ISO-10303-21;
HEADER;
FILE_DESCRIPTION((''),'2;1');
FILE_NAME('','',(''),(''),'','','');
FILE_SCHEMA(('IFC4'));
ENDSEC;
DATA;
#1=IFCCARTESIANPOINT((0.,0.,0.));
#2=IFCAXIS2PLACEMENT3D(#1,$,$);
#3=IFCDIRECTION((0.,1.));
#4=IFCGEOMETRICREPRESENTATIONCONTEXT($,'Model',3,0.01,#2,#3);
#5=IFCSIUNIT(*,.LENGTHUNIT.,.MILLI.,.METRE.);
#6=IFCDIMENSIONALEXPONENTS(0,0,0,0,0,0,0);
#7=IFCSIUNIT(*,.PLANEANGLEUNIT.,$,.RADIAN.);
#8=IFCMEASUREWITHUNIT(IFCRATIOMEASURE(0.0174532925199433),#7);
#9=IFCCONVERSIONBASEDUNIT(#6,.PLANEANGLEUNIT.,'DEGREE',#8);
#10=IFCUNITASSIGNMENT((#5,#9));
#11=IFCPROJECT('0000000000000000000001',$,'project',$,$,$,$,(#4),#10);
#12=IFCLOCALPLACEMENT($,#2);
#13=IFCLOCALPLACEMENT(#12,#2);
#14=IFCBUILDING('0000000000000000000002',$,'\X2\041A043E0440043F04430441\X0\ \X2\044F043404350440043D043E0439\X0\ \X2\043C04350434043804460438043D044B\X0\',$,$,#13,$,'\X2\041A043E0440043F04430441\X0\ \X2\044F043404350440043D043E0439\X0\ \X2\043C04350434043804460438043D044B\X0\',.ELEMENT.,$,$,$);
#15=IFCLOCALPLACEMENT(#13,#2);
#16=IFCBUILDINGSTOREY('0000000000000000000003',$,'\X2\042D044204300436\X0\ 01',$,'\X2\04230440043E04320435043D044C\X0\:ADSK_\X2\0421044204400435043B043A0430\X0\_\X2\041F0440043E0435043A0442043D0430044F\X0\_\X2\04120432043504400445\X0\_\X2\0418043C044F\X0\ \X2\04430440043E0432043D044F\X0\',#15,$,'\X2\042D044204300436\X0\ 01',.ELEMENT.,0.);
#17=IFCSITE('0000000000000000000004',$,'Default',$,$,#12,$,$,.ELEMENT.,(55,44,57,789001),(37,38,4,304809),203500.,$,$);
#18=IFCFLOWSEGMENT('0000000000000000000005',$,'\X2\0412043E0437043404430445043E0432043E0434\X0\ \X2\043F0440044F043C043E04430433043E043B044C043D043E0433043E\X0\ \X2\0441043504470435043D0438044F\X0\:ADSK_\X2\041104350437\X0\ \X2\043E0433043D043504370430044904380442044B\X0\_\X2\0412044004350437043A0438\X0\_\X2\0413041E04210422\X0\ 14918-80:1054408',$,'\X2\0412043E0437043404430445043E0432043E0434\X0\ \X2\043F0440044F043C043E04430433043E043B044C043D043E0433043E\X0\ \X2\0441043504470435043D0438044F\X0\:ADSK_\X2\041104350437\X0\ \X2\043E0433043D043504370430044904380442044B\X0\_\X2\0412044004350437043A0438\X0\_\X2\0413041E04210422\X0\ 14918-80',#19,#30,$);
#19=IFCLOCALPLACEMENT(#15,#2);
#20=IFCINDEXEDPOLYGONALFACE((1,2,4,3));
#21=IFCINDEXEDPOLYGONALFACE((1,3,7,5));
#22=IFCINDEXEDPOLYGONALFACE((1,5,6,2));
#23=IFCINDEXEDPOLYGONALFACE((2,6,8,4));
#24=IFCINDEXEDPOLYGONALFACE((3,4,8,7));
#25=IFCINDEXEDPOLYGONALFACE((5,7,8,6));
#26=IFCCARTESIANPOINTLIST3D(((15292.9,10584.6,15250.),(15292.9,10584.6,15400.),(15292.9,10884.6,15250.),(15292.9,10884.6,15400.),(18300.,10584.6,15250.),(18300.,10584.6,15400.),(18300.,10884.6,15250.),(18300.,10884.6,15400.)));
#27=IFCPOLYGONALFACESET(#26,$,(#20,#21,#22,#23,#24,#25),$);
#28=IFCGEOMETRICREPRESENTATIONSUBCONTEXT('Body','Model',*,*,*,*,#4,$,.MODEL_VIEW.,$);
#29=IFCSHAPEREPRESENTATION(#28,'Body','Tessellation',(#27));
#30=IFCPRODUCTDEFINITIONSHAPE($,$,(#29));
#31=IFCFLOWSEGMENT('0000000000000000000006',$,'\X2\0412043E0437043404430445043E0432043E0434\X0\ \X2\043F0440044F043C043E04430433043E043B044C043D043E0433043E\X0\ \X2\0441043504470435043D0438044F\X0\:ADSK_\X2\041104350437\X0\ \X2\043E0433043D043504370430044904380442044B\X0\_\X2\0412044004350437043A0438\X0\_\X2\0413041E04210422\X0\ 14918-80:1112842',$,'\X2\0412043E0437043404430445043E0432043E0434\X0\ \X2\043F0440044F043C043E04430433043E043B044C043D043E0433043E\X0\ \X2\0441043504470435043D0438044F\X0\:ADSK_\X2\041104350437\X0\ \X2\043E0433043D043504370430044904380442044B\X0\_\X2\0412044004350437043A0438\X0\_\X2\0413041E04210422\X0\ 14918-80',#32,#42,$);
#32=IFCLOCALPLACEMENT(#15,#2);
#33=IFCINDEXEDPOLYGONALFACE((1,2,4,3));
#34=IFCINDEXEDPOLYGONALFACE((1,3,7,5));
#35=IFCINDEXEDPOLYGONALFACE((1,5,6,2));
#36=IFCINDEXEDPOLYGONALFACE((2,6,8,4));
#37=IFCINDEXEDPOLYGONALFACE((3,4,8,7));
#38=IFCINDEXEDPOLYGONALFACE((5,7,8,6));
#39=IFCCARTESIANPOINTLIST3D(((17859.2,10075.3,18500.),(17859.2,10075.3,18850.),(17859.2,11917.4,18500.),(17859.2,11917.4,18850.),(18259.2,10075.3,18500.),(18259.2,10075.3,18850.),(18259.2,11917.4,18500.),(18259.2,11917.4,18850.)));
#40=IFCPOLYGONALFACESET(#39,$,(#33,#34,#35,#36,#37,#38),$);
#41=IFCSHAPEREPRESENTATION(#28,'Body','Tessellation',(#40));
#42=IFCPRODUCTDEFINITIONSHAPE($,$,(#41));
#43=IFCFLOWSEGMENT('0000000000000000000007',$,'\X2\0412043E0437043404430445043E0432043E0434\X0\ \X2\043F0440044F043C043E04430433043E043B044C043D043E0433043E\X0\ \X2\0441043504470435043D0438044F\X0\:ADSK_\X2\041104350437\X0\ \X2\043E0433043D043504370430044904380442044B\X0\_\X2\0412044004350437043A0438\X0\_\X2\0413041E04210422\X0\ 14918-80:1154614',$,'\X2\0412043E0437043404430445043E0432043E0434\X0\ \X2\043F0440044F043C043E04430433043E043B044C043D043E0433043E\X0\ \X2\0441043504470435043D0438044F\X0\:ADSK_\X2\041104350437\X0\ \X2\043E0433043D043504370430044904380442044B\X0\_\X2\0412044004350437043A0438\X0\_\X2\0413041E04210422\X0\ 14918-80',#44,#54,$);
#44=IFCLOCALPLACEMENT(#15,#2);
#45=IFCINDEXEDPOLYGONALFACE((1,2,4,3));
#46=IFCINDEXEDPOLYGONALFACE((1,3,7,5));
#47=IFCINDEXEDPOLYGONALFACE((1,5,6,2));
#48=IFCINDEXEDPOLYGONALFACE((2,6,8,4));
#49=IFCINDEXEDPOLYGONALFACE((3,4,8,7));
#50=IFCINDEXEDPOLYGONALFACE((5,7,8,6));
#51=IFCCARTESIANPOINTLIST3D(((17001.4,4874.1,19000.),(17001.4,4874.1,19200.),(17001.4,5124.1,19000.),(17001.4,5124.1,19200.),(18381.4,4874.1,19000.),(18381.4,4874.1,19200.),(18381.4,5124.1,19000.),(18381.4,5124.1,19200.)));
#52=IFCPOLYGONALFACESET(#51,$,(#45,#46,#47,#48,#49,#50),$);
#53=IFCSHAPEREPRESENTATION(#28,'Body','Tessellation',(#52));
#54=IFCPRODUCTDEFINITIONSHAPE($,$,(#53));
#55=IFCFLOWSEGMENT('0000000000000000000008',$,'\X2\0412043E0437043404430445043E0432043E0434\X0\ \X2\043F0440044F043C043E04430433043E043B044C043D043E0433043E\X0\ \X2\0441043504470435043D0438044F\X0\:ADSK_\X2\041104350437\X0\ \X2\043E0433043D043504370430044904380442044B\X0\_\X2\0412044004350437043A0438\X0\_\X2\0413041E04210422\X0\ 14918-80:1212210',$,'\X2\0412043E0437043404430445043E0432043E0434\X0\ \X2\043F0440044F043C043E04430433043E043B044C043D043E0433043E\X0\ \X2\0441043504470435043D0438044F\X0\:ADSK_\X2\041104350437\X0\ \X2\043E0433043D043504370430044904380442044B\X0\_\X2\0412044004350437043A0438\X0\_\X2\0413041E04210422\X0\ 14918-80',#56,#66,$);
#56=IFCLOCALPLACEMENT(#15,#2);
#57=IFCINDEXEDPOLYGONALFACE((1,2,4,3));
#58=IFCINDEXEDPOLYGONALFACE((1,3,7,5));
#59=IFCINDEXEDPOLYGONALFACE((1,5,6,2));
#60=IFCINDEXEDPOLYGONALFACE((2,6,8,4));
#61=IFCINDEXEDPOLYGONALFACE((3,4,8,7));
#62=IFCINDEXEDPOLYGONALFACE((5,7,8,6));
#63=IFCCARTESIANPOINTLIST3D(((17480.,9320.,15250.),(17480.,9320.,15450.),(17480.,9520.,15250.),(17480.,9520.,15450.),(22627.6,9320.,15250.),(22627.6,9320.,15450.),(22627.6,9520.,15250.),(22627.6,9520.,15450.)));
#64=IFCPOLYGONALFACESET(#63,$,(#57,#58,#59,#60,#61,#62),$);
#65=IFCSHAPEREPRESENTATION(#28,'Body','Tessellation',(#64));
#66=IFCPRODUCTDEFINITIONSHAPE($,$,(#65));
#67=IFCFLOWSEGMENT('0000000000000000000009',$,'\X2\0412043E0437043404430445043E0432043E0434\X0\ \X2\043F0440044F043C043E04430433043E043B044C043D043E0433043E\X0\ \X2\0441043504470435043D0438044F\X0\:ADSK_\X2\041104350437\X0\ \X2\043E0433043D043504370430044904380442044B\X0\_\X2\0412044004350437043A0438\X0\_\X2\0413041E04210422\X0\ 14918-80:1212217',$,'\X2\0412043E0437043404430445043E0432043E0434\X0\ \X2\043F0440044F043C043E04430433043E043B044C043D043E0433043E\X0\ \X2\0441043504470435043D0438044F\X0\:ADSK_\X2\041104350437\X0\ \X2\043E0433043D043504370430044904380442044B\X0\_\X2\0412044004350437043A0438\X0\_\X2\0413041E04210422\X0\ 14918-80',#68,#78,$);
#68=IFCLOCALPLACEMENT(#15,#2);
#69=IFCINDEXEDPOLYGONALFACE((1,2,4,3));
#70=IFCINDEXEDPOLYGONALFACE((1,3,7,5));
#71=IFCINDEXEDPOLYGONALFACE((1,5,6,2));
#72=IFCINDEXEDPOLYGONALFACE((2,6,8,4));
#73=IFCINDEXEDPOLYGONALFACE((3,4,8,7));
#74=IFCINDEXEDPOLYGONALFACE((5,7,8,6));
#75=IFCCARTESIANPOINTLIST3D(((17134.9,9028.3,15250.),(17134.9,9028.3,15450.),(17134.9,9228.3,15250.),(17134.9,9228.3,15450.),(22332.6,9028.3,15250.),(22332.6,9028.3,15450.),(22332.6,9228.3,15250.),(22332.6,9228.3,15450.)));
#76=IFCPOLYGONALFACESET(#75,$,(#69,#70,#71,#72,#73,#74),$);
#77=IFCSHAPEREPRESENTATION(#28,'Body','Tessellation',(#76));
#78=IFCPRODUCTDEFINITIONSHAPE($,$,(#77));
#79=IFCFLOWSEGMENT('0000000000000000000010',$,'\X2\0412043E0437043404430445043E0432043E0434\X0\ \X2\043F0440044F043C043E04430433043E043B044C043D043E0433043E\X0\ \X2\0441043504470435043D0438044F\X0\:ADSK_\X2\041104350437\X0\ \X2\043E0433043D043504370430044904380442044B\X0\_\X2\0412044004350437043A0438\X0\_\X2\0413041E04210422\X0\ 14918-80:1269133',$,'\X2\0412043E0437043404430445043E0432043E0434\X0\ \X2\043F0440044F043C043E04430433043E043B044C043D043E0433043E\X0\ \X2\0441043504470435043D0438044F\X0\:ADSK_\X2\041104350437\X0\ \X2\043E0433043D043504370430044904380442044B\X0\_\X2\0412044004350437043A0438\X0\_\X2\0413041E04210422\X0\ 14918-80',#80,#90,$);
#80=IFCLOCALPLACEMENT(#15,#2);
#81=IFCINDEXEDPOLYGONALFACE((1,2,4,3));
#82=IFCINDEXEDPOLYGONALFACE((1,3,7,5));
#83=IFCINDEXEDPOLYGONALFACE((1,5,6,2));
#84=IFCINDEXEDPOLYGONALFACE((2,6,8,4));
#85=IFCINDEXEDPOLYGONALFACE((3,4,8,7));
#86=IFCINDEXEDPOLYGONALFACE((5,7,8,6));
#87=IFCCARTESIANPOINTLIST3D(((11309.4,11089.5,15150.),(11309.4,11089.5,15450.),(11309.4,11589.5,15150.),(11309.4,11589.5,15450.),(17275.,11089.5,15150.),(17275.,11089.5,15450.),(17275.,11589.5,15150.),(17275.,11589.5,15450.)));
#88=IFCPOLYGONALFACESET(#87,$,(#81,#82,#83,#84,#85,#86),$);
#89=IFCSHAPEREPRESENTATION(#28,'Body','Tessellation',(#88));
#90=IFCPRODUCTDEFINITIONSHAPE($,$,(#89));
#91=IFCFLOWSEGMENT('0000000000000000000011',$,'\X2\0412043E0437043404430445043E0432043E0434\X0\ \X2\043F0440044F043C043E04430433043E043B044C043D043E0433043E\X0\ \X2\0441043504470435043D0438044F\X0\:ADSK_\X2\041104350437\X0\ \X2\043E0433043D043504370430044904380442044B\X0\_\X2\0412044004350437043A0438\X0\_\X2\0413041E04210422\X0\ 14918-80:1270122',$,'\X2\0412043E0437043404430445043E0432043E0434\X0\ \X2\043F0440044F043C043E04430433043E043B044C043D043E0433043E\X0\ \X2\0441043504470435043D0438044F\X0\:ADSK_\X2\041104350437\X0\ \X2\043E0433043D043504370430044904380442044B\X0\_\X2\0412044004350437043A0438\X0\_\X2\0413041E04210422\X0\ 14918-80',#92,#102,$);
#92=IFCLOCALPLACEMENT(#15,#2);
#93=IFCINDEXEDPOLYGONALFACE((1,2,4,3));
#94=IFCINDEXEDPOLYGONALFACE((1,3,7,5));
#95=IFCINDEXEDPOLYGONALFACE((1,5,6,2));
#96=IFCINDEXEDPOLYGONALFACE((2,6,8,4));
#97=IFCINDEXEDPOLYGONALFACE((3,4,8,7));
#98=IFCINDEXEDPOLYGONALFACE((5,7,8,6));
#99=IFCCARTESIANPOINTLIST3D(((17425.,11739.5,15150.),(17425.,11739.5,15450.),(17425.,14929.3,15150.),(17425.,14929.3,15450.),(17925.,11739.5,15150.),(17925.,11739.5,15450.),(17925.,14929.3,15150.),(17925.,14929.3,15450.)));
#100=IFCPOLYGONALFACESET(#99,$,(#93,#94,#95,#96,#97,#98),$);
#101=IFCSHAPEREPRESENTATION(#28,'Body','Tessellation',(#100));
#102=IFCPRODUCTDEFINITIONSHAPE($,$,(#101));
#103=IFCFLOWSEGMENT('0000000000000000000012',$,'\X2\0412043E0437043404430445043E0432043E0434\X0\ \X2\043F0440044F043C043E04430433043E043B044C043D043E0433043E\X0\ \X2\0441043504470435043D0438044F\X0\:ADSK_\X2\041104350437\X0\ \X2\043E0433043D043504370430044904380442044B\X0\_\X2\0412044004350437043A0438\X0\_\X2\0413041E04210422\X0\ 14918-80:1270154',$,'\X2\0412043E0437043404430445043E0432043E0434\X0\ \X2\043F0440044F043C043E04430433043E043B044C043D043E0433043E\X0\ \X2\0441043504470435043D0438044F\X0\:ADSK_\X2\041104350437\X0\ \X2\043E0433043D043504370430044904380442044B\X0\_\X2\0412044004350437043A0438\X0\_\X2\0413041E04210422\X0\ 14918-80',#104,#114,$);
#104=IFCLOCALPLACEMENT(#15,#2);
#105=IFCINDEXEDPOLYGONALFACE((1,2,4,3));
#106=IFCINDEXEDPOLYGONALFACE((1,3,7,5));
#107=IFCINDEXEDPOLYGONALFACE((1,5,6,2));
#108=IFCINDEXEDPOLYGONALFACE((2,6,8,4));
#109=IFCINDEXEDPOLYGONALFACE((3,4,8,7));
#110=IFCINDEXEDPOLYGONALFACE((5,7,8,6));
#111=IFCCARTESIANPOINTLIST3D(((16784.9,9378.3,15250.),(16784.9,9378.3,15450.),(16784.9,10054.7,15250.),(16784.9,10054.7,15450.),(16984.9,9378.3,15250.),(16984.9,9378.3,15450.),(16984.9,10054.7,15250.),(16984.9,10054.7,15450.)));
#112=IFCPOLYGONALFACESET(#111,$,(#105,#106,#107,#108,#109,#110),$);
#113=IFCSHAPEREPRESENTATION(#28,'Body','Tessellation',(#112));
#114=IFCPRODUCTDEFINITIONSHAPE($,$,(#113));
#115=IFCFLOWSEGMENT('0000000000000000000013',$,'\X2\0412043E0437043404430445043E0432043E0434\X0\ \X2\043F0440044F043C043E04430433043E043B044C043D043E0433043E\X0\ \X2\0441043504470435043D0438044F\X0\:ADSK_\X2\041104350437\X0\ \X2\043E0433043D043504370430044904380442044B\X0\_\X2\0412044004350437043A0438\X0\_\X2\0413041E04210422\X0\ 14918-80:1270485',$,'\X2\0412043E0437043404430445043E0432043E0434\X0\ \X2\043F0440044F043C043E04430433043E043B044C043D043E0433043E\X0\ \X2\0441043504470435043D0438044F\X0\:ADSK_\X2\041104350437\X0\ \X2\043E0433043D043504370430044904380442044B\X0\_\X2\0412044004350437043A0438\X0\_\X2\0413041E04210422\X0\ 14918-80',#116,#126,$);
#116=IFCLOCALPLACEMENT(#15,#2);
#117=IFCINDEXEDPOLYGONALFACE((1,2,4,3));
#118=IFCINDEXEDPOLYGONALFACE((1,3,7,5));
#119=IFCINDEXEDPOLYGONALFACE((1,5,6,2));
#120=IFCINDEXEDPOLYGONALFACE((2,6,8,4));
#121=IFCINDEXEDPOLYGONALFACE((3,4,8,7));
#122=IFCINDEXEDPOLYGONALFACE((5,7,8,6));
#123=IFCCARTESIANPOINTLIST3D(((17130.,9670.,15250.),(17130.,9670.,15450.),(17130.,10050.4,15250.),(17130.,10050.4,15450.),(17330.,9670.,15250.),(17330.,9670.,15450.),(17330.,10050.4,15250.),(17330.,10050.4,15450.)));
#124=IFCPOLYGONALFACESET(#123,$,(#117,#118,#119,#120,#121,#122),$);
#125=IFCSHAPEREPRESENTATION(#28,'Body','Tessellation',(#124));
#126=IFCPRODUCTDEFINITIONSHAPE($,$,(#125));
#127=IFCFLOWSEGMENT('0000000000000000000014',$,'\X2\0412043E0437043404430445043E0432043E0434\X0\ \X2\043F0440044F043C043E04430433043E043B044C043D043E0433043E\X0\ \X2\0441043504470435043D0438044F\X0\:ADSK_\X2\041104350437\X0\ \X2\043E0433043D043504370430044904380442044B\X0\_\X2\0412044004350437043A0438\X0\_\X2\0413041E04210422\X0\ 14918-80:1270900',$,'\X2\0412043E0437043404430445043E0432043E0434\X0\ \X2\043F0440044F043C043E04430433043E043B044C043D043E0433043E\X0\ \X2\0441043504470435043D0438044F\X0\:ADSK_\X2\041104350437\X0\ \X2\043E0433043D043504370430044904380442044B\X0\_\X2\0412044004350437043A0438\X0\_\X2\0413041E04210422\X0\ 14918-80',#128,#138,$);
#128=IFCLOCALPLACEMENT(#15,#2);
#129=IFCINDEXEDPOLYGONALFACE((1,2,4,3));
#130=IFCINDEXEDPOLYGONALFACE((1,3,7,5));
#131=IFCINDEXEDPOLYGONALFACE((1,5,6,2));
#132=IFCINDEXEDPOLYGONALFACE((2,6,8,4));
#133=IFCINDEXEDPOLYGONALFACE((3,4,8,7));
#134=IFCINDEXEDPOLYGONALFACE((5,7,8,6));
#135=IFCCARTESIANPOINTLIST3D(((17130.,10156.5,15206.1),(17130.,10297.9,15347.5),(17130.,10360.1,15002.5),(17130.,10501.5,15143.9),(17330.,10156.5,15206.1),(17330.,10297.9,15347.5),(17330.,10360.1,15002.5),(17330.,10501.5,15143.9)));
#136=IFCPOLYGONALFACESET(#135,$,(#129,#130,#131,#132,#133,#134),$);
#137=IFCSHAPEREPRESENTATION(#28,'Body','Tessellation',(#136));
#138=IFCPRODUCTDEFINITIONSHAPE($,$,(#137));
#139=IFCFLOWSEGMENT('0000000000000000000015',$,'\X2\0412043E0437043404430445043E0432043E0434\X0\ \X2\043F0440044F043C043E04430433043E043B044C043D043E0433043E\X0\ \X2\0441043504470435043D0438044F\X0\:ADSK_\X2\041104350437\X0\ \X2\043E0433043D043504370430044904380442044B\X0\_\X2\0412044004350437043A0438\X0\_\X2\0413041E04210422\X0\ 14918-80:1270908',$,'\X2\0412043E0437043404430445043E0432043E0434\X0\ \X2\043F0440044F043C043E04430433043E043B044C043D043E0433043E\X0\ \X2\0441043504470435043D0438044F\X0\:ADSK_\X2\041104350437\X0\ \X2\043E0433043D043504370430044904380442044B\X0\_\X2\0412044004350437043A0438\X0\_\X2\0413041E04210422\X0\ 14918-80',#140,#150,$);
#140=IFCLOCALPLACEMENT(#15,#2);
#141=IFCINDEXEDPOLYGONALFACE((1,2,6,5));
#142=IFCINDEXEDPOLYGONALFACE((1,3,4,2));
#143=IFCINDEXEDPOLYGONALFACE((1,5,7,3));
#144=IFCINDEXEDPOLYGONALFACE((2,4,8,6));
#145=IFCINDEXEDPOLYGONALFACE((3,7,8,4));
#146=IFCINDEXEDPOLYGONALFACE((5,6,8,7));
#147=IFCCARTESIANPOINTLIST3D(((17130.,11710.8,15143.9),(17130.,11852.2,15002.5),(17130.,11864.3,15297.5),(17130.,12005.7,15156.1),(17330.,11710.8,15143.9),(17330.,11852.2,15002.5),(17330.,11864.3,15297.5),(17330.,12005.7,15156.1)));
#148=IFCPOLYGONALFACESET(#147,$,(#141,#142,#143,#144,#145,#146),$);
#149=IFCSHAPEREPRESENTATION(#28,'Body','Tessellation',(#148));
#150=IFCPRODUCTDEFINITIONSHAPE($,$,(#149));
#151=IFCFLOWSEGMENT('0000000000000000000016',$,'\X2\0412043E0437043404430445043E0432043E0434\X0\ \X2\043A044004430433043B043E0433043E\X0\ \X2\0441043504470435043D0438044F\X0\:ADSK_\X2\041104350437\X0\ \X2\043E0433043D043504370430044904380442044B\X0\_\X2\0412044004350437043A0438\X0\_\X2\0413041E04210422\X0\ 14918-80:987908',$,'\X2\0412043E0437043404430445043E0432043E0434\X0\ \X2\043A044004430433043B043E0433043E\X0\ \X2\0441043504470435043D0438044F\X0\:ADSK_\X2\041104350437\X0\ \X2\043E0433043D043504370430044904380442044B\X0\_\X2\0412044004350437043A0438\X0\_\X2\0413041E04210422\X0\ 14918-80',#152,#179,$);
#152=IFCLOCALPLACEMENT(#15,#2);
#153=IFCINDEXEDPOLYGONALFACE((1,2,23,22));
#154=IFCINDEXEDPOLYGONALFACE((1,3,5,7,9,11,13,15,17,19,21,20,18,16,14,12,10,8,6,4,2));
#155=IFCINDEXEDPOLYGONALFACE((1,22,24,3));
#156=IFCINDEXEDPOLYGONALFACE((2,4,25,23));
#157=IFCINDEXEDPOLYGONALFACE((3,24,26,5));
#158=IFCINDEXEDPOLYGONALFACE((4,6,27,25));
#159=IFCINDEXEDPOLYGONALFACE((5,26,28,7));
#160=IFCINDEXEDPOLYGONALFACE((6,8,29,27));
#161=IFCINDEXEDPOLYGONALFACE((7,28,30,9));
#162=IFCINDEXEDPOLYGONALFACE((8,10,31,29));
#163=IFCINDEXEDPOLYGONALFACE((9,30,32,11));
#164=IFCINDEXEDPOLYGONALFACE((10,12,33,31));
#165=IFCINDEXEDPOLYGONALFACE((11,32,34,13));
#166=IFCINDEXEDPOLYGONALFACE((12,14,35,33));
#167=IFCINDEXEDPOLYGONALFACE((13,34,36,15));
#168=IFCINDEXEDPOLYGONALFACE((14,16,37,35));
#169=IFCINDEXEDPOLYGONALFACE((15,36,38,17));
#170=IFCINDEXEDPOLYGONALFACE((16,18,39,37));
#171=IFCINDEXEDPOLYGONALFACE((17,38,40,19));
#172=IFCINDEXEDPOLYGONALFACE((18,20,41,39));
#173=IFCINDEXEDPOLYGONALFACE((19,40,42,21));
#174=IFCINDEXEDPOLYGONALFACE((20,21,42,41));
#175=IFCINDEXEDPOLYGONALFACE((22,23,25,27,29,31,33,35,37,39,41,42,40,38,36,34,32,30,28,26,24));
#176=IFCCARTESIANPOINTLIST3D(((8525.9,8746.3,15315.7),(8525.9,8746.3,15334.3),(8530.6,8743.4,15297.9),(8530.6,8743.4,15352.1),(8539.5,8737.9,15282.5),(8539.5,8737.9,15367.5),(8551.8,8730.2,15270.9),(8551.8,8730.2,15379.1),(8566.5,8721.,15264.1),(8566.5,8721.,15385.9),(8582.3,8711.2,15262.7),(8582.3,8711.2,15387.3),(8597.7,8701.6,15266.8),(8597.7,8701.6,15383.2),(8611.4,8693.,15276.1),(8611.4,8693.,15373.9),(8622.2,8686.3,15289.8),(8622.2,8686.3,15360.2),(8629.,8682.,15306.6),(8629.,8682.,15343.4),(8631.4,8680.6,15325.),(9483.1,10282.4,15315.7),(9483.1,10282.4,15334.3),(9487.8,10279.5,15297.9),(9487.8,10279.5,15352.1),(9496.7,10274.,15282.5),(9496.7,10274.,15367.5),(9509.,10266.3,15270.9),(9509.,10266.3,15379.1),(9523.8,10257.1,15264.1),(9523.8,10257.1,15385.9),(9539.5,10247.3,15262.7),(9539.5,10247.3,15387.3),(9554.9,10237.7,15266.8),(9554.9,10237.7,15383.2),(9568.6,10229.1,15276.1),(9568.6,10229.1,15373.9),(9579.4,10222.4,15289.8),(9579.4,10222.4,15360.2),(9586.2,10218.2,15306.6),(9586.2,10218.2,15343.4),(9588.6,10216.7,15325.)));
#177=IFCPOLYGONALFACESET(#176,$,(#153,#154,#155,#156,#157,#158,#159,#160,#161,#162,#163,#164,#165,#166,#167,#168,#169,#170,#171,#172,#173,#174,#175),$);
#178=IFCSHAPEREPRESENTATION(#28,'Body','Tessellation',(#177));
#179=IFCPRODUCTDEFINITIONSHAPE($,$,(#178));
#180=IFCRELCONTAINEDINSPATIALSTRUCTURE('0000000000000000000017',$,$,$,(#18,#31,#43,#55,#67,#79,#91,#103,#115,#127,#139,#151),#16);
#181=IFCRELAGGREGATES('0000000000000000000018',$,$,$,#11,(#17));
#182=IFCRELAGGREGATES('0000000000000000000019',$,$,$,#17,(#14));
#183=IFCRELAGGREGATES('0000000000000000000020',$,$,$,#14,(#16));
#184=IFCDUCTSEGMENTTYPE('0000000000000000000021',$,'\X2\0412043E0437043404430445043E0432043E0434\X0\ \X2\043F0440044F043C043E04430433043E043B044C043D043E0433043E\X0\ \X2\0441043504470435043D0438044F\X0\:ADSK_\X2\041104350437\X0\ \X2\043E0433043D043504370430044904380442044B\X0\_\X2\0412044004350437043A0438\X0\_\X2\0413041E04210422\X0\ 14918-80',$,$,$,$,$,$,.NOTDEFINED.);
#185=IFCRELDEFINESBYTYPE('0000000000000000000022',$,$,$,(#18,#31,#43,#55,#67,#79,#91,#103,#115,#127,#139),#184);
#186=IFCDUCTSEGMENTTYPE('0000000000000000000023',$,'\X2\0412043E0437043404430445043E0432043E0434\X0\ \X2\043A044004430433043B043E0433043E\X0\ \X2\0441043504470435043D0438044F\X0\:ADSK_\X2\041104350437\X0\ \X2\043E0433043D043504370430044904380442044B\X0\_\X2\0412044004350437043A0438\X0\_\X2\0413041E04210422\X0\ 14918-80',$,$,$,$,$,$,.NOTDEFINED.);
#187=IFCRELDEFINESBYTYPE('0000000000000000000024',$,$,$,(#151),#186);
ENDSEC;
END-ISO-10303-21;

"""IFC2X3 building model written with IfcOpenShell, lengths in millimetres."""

from ifc_helpers import new_model, entity, si_unit, converted_unit, direction, frame, frame_2d, origin, origin_2d_with_axis, place, context, subcontext, project, spatial, rectangle, circle, extrude, type_object, element, save


model = new_model("IFC2X3")

# Units and contexts
model_context = context("Model", 3, precision=0.01, world=origin(), true_north=direction((0.0, 1.0)))
body_context = subcontext(model_context, "Body", "Model", "MODEL_VIEW")
ifc_project = project(units=[si_unit("LENGTHUNIT", "METRE", prefix="MILLI"), converted_unit("PLANEANGLEUNIT", "DEGREE", entity("IfcRatioMeasure", 0.0174532925199433), si_unit("PLANEANGLEUNIT", "RADIAN"), dimensions=[0, 0, 0, 0, 0, 0, 0])], contexts=[model_context])

# Site, building, storey
site_placement = place(None, origin())
site = spatial("IfcSite", under=ifc_project, at=site_placement, Name="Default", CompositionType="ELEMENT", RefLatitude=(55, 44, 57, 789001), RefLongitude=(37, 38, 4, 304809), RefElevation=203500.0)
building_placement = place(site_placement, origin())
building = spatial("IfcBuilding", under=site, at=building_placement, Name="Корпус ядерной медицины", LongName="Корпус ядерной медицины", CompositionType="ELEMENT")
storey_placement = place(building_placement, origin())
storey = spatial("IfcBuildingStorey", under=building, at=storey_placement, Name="Этаж 01", ObjectType="Уровень:ADSK_Стрелка_Проектная_Вверх_Имя уровня", LongName="Этаж 01", CompositionType="ELEMENT", Elevation=0.0)

# Flow segments
duct_segment_type_1 = type_object("IfcDuctSegmentType", Name="Воздуховод прямоугольного сечения:ADSK_Без огнезащиты_Врезки_ГОСТ 14918-80", PredefinedType="NOTDEFINED")
flow_segment_1_placement = place(storey_placement, frame((15292.9, 10584.6, 15250.0)))
element("IfcFlowSegment", 1, at=flow_segment_1_placement, inside=storey, type_object=duct_segment_type_1, Name="Воздуховод прямоугольного сечения:ADSK_Без огнезащиты_Врезки_ГОСТ 14918-80:1054408", ObjectType="Воздуховод прямоугольного сечения:ADSK_Без огнезащиты_Врезки_ГОСТ 14918-80", context=body_context, shape_type="SweptSolid", body=[
    extrude(rectangle(XDim=3007.1, YDim=300.0, at=origin_2d_with_axis()), frame((1503.5, 150.0, 0.0)), (0.0, 0.0, 1.0), 150.0),
])
flow_segment_2_placement = place(storey_placement, frame((17859.2, 10075.3, 18500.0)))
element("IfcFlowSegment", 2, at=flow_segment_2_placement, inside=storey, type_object=duct_segment_type_1, Name="Воздуховод прямоугольного сечения:ADSK_Без огнезащиты_Врезки_ГОСТ 14918-80:1112842", ObjectType="Воздуховод прямоугольного сечения:ADSK_Без огнезащиты_Врезки_ГОСТ 14918-80", context=body_context, shape_type="SweptSolid", body=[
    extrude(rectangle(XDim=1842.1, YDim=400.0, at=origin_2d_with_axis()), frame((200.0, 921.0, 0.0), z_axis=(0.0, 0.0, 1.0), x_axis=(0.0, -1.0, 0.0)), (0.0, 0.0, 1.0), 350.0),
])
flow_segment_3_placement = place(storey_placement, frame((17001.4, 4874.1, 19000.0)))
element("IfcFlowSegment", 3, at=flow_segment_3_placement, inside=storey, type_object=duct_segment_type_1, Name="Воздуховод прямоугольного сечения:ADSK_Без огнезащиты_Врезки_ГОСТ 14918-80:1154614", ObjectType="Воздуховод прямоугольного сечения:ADSK_Без огнезащиты_Врезки_ГОСТ 14918-80", context=body_context, shape_type="SweptSolid", body=[
    extrude(rectangle(XDim=1380.0, YDim=250.0, at=origin_2d_with_axis()), frame((690.0, 125.0, 0.0), z_axis=(0.0, 0.0, 1.0), x_axis=(-1.0, 0.0, 0.0)), (0.0, 0.0, 1.0), 200.0),
])
flow_segment_4_placement = place(storey_placement, frame((17480.0, 9320.0, 15250.0)))
element("IfcFlowSegment", 4, at=flow_segment_4_placement, inside=storey, type_object=duct_segment_type_1, Name="Воздуховод прямоугольного сечения:ADSK_Без огнезащиты_Врезки_ГОСТ 14918-80:1212210", ObjectType="Воздуховод прямоугольного сечения:ADSK_Без огнезащиты_Врезки_ГОСТ 14918-80", context=body_context, shape_type="SweptSolid", body=[
    extrude(rectangle(XDim=5147.6, YDim=200.0, at=origin_2d_with_axis()), frame((2573.8, 100.0, 0.0), z_axis=(0.0, 0.0, 1.0), x_axis=(-1.0, 0.0, 0.0)), (0.0, 0.0, 1.0), 200.0),
])
flow_segment_5_placement = place(storey_placement, frame((17134.9, 9028.3, 15250.0)))
element("IfcFlowSegment", 5, at=flow_segment_5_placement, inside=storey, type_object=duct_segment_type_1, Name="Воздуховод прямоугольного сечения:ADSK_Без огнезащиты_Врезки_ГОСТ 14918-80:1212217", ObjectType="Воздуховод прямоугольного сечения:ADSK_Без огнезащиты_Врезки_ГОСТ 14918-80", context=body_context, shape_type="SweptSolid", body=[
    extrude(rectangle(XDim=5197.6, YDim=200.0, at=origin_2d_with_axis()), frame((2598.8, 100.0, 0.0), z_axis=(0.0, 0.0, 1.0), x_axis=(-1.0, 0.0, 0.0)), (0.0, 0.0, 1.0), 200.0),
])
flow_segment_6_placement = place(storey_placement, frame((11309.4, 11089.5, 15150.0)))
element("IfcFlowSegment", 6, at=flow_segment_6_placement, inside=storey, type_object=duct_segment_type_1, Name="Воздуховод прямоугольного сечения:ADSK_Без огнезащиты_Врезки_ГОСТ 14918-80:1269133", ObjectType="Воздуховод прямоугольного сечения:ADSK_Без огнезащиты_Врезки_ГОСТ 14918-80", context=body_context, shape_type="SweptSolid", body=[
    extrude(rectangle(XDim=5965.6, YDim=500.0, at=origin_2d_with_axis()), frame((2982.8, 250.0, 0.0)), (0.0, 0.0, 1.0), 300.0),
])
flow_segment_7_placement = place(storey_placement, frame((17425.0, 11739.5, 15150.0)))
element("IfcFlowSegment", 7, at=flow_segment_7_placement, inside=storey, type_object=duct_segment_type_1, Name="Воздуховод прямоугольного сечения:ADSK_Без огнезащиты_Врезки_ГОСТ 14918-80:1270122", ObjectType="Воздуховод прямоугольного сечения:ADSK_Без огнезащиты_Врезки_ГОСТ 14918-80", context=body_context, shape_type="SweptSolid", body=[
    extrude(rectangle(XDim=3189.8, YDim=500.0, at=origin_2d_with_axis()), frame((250.0, 1594.9, 0.0), z_axis=(0.0, 0.0, 1.0), x_axis=(0.0, -1.0, 0.0)), (0.0, 0.0, 1.0), 300.0),
])
flow_segment_8_placement = place(storey_placement, frame((16784.9, 9378.3, 15250.0)))
element("IfcFlowSegment", 8, at=flow_segment_8_placement, inside=storey, type_object=duct_segment_type_1, Name="Воздуховод прямоугольного сечения:ADSK_Без огнезащиты_Врезки_ГОСТ 14918-80:1270154", ObjectType="Воздуховод прямоугольного сечения:ADSK_Без огнезащиты_Врезки_ГОСТ 14918-80", context=body_context, shape_type="SweptSolid", body=[
    extrude(rectangle(XDim=676.4, YDim=200.0, at=origin_2d_with_axis()), frame((100.0, 338.2, 0.0), z_axis=(0.0, 0.0, 1.0), x_axis=(0.0, 1.0, 0.0)), (0.0, 0.0, 1.0), 200.0),
])
flow_segment_9_placement = place(storey_placement, frame((17130.0, 9670.0, 15250.0)))
element("IfcFlowSegment", 9, at=flow_segment_9_placement, inside=storey, type_object=duct_segment_type_1, Name="Воздуховод прямоугольного сечения:ADSK_Без огнезащиты_Врезки_ГОСТ 14918-80:1270485", ObjectType="Воздуховод прямоугольного сечения:ADSK_Без огнезащиты_Врезки_ГОСТ 14918-80", context=body_context, shape_type="SweptSolid", body=[
    extrude(rectangle(XDim=380.4, YDim=200.0, at=origin_2d_with_axis()), frame((100.0, 190.2, 0.0), z_axis=(0.0, 0.0, 1.0), x_axis=(0.0, 1.0, 0.0)), (0.0, 0.0, 1.0), 200.0),
])
flow_segment_10_placement = place(storey_placement, frame((17130.0, 10156.5, 15002.5)))
element("IfcFlowSegment", 10, at=flow_segment_10_placement, inside=storey, type_object=duct_segment_type_1, Name="Воздуховод прямоугольного сечения:ADSK_Без огнезащиты_Врезки_ГОСТ 14918-80:1270900", ObjectType="Воздуховод прямоугольного сечения:ADSK_Без огнезащиты_Врезки_ГОСТ 14918-80", context=body_context, shape_type="SweptSolid", body=[
    extrude(rectangle(XDim=200.0, YDim=200.0, at=frame_2d((0.0, 0.0), x_axis=(0.0, 1.0))), frame((100.0, 274.3, 70.7), z_axis=(0.0, -0.707107, 0.707107), x_axis=(1.0, 0.0, 0.0)), (0.0, 0.0, 1.0), 287.9),
])
flow_segment_11_placement = place(storey_placement, frame((17130.0, 11710.8, 15002.5)))
element("IfcFlowSegment", 11, at=flow_segment_11_placement, inside=storey, type_object=duct_segment_type_1, Name="Воздуховод прямоугольного сечения:ADSK_Без огнезащиты_Врезки_ГОСТ 14918-80:1270908", ObjectType="Воздуховод прямоугольного сечения:ADSK_Без огнезащиты_Врезки_ГОСТ 14918-80", context=body_context, shape_type="SweptSolid", body=[
    extrude(rectangle(XDim=200.0, YDim=200.0, at=frame_2d((0.0, 0.0), x_axis=(0.0, 1.0))), frame((100.0, 70.7, 70.7), z_axis=(0.0, 0.707107, 0.707107), x_axis=(-1.0, 0.0, 0.0)), (0.0, 0.0, 1.0), 217.2),
])
duct_segment_type_2 = type_object("IfcDuctSegmentType", Name="Воздуховод круглого сечения:ADSK_Без огнезащиты_Врезки_ГОСТ 14918-80", PredefinedType="NOTDEFINED")
flow_segment_12_placement = place(storey_placement, frame((8523.7, 8679.0, 15260.9)))
element("IfcFlowSegment", 12, at=flow_segment_12_placement, inside=storey, type_object=duct_segment_type_2, Name="Воздуховод круглого сечения:ADSK_Без огнезащиты_Врезки_ГОСТ 14918-80:987908", ObjectType="Воздуховод круглого сечения:ADSK_Без огнезащиты_Врезки_ГОСТ 14918-80", context=body_context, shape_type="SweptSolid", body=[
    extrude(circle(Radius=62.5, at=origin_2d_with_axis()), frame((54.6, 34.6, 64.1), z_axis=(0.528858, 0.84871, 0.0), x_axis=(0.84871, -0.528858, 0.0)), (0.0, 0.0, 1.0), 1809.9),
])

save(model, "model.ifc")
